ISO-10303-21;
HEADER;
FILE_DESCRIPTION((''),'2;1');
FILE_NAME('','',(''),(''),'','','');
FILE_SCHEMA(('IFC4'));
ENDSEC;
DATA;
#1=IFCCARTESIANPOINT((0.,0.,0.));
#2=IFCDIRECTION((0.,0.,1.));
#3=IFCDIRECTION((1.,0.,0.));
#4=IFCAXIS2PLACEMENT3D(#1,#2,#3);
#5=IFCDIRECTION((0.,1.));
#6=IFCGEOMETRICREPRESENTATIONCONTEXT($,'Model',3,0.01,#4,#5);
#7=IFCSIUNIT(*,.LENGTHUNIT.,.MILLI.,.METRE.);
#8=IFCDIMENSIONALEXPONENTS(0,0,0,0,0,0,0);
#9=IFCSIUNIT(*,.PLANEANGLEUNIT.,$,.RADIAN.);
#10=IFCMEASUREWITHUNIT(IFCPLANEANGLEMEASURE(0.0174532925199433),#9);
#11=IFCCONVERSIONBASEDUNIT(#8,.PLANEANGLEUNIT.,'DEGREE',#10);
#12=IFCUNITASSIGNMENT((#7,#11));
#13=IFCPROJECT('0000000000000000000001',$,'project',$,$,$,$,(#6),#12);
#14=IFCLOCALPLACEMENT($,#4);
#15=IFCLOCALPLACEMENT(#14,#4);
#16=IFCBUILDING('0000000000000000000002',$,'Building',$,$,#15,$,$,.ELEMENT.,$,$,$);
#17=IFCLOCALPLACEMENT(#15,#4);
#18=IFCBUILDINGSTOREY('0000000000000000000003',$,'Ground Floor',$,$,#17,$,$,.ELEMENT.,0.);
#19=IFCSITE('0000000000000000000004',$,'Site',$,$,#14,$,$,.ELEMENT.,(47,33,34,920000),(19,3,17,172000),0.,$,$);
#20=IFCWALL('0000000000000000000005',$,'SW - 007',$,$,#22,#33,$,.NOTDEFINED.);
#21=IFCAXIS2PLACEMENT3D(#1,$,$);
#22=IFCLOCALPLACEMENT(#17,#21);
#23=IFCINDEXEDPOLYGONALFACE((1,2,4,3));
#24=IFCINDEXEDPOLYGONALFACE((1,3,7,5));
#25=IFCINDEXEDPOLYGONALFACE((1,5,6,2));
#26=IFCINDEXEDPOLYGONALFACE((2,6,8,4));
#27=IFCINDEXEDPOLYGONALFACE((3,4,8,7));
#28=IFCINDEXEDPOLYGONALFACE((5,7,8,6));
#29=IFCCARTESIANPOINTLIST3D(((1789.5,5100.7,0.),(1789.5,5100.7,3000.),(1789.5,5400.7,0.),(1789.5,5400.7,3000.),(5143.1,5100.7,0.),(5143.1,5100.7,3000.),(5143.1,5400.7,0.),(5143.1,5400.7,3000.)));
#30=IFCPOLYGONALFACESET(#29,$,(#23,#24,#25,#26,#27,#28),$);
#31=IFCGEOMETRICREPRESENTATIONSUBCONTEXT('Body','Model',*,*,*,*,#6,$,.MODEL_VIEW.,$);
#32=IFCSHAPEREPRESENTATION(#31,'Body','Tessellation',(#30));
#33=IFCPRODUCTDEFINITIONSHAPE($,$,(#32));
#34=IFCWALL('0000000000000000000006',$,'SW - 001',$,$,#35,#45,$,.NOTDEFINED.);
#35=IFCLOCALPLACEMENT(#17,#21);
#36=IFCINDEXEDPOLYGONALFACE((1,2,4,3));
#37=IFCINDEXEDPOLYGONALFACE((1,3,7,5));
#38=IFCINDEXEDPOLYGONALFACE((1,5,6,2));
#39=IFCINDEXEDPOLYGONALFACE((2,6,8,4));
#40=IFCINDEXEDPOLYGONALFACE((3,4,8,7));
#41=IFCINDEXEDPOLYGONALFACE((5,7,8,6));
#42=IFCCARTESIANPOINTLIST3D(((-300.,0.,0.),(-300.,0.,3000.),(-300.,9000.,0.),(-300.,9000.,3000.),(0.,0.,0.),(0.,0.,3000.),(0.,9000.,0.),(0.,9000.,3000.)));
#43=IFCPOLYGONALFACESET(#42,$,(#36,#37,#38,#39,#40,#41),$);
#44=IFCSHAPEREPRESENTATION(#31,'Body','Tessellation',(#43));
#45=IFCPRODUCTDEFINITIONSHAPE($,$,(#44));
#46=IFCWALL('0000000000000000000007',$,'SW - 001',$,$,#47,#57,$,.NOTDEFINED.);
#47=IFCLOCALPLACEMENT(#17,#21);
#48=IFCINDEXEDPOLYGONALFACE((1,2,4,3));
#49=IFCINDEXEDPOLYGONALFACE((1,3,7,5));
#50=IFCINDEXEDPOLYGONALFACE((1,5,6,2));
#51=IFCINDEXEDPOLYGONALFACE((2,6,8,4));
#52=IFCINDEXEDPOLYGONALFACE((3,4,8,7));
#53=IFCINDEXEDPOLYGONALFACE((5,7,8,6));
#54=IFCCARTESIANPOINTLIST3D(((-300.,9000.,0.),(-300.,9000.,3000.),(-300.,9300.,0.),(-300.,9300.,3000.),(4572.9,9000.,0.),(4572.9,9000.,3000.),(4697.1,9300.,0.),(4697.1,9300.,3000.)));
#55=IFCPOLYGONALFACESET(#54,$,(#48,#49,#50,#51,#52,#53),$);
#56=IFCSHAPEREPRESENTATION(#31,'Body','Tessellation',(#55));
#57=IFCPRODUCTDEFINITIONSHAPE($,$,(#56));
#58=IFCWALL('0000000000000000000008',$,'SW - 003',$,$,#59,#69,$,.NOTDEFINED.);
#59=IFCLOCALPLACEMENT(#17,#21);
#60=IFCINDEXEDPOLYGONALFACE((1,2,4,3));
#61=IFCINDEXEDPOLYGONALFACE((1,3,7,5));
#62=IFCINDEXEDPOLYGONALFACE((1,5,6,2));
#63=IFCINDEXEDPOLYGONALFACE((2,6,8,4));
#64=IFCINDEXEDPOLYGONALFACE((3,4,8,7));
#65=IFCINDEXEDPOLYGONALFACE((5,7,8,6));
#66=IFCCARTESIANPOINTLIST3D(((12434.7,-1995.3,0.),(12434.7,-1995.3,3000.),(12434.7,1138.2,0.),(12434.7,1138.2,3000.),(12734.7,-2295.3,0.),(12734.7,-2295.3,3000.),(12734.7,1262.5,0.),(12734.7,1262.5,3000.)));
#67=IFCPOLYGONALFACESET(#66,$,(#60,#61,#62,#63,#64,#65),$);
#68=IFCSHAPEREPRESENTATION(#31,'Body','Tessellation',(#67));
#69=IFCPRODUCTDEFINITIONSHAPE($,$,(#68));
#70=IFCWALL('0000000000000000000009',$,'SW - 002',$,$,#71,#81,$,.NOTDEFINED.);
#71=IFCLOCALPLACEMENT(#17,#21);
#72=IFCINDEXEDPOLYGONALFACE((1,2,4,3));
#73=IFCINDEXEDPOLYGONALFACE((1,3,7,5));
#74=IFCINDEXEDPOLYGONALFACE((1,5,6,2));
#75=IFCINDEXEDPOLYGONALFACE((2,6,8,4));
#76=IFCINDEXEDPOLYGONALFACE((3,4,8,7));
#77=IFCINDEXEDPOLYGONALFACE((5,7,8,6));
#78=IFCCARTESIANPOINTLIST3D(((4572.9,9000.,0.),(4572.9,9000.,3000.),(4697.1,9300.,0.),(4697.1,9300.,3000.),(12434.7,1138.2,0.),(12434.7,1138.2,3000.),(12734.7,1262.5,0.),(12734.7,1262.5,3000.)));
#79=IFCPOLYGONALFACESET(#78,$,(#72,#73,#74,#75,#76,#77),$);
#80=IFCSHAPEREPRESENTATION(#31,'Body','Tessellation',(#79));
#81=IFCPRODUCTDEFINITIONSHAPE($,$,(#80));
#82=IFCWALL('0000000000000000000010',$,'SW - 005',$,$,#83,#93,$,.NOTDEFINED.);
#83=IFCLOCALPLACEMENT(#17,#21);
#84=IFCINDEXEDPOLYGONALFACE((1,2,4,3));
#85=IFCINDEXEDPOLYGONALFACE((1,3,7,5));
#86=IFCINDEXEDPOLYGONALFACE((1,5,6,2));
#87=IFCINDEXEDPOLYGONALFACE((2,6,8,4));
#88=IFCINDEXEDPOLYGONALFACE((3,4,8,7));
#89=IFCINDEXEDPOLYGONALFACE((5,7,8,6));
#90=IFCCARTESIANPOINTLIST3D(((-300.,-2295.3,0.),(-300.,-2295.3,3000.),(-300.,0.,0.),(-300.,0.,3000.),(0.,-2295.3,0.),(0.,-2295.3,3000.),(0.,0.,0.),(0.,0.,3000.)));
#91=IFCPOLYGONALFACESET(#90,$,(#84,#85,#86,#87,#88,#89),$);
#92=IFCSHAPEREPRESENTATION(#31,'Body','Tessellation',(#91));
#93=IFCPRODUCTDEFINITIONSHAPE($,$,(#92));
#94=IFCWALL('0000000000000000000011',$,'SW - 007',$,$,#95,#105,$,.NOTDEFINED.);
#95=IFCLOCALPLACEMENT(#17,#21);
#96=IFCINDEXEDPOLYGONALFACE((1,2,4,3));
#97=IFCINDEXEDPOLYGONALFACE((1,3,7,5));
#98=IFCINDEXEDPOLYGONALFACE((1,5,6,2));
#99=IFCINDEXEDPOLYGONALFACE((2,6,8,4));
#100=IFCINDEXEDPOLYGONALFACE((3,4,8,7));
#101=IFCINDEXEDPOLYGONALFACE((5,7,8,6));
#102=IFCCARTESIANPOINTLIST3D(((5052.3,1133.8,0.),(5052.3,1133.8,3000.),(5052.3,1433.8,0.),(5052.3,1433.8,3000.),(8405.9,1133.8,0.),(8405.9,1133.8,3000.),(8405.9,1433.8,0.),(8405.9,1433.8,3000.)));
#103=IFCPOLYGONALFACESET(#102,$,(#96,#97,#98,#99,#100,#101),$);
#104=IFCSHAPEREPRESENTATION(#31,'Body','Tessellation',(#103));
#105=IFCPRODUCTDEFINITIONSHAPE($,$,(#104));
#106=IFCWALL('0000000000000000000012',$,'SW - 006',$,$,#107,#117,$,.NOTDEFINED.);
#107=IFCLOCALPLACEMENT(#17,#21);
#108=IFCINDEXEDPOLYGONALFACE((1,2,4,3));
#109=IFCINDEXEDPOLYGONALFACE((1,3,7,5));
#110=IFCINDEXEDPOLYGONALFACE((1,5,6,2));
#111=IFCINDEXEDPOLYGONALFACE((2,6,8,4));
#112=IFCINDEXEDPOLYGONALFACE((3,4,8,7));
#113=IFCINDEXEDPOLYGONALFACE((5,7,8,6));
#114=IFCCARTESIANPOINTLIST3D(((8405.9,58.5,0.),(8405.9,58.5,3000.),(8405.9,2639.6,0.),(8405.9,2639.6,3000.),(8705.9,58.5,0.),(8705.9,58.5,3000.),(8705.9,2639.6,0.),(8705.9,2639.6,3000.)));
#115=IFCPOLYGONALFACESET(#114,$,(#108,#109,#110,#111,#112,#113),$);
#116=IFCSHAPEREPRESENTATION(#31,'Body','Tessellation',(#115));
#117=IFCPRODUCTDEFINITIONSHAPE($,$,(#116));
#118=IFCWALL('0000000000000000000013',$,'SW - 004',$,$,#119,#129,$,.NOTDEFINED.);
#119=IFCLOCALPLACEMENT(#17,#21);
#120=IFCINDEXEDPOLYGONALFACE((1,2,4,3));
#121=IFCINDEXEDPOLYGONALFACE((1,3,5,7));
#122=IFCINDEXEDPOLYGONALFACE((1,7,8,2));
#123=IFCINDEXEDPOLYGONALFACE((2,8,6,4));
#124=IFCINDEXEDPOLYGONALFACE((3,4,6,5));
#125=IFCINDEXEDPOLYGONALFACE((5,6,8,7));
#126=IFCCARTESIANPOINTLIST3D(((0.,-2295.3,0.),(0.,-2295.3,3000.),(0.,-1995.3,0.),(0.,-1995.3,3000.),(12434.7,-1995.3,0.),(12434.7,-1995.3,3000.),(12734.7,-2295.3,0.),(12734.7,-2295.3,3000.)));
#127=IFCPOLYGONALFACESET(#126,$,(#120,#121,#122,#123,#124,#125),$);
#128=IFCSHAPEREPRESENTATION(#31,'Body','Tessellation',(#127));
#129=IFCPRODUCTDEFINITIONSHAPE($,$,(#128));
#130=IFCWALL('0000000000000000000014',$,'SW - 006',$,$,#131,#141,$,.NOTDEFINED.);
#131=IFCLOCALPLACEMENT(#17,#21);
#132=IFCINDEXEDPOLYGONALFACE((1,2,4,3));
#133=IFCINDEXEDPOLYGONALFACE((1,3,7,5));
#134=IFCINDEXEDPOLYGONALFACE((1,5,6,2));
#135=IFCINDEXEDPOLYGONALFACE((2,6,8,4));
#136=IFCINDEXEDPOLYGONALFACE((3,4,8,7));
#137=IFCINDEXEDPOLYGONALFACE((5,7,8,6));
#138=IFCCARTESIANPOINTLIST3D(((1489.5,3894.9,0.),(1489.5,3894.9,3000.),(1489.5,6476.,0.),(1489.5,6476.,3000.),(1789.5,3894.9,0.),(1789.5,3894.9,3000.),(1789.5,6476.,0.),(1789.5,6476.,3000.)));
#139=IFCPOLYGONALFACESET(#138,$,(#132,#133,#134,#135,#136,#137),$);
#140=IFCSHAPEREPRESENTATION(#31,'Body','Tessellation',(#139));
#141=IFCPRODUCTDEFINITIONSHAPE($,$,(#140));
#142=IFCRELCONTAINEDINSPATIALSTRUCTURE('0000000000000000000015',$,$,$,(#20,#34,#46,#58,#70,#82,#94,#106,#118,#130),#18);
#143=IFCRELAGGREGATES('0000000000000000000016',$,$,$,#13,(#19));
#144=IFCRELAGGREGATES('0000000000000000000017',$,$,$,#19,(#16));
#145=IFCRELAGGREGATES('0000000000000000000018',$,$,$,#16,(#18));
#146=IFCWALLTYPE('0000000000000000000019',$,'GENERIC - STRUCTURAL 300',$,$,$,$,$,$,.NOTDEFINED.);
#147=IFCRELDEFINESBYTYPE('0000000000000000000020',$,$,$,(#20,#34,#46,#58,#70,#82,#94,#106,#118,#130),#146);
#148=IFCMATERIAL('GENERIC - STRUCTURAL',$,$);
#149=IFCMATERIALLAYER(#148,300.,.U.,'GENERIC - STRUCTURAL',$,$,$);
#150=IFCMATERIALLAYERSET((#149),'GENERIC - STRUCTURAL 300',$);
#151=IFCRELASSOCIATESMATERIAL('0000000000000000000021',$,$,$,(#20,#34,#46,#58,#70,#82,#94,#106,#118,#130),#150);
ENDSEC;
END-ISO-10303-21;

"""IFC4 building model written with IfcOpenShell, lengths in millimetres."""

from ifc_helpers import new_model, entity, si_unit, converted_unit, direction, frame, origin_with_axes, place, context, subcontext, project, spatial, line, indexed_curve, outline, extrude, material, layer, layer_set, layer_usage, type_object, element, save


model = new_model("IFC4")

# Units and contexts
model_context = context("Model", 3, precision=0.01, world=origin_with_axes(), true_north=direction((0.0, 1.0)))
body_context = subcontext(model_context, "Body", "Model", "MODEL_VIEW")
ifc_project = project(units=[si_unit("LENGTHUNIT", "METRE", prefix="MILLI"), converted_unit("PLANEANGLEUNIT", "DEGREE", entity("IfcPlaneAngleMeasure", 0.0174532925199433), si_unit("PLANEANGLEUNIT", "RADIAN"), dimensions=[0, 0, 0, 0, 0, 0, 0])], contexts=[model_context])

# Site, building, storey
site_placement = place(None, origin_with_axes())
site = spatial("IfcSite", under=ifc_project, at=site_placement, Name="Site", CompositionType="ELEMENT", RefLatitude=(47, 33, 34, 920000), RefLongitude=(19, 3, 17, 172000), RefElevation=0.0)
building_placement = place(site_placement, origin_with_axes())
building = spatial("IfcBuilding", under=site, at=building_placement, Name="Building", CompositionType="ELEMENT")
storey_placement = place(building_placement, origin_with_axes())
storey = spatial("IfcBuildingStorey", under=building, at=storey_placement, Name="Ground Floor", CompositionType="ELEMENT", Elevation=0.0)

# Walls
ifc_material = material(Name="GENERIC - STRUCTURAL")
ifc_layer = layer(ifc_material, 300.0, ventilated="UNKNOWN", Name="GENERIC - STRUCTURAL")
ifc_layer_set = layer_set([ifc_layer], Name="GENERIC - STRUCTURAL 300")
ifc_layer_usage_1 = layer_usage(ifc_layer_set, "AXIS2", "POSITIVE", 0.0)
wall_type = type_object("IfcWallType", Name="GENERIC - STRUCTURAL 300", PredefinedType="NOTDEFINED")
wall_1_placement = place(storey_placement, frame((1789.5, 5100.7, 0.0), z_axis=(0.0, 0.0, 1.0), x_axis=(1.0, 0.0, 0.0)))
element("IfcWall", 1, at=wall_1_placement, inside=storey, type_object=wall_type, material=ifc_layer_usage_1, Name="SW - 007", PredefinedType="NOTDEFINED", context=body_context, shape_type="SweptSolid", body=[
    extrude(outline(indexed_curve([(0.0, 0.0), (3353.6, 0.0), (3353.6, 300.0), (0.0, 300.0)], segments=[line(1, 2, 3, 4, 1)])), origin_with_axes(), (0.0, 0.0, 1.0), 3000.0),
])
ifc_layer_usage_2 = layer_usage(ifc_layer_set, "AXIS2", "POSITIVE", 0.0)
wall_2_placement = place(storey_placement, frame((0.0, 0.0, 0.0), z_axis=(0.0, 0.0, 1.0), x_axis=(0.0, 1.0, 0.0)))
element("IfcWall", 2, at=wall_2_placement, inside=storey, type_object=wall_type, material=ifc_layer_usage_2, Name="SW - 001", PredefinedType="NOTDEFINED", context=body_context, shape_type="SweptSolid", body=[
    extrude(outline(indexed_curve([(0.0, 0.0), (9000.0, 0.0), (9000.0, 300.0), (0.0, 300.0)], segments=[line(1, 2, 3, 4, 1)])), origin_with_axes(), (0.0, 0.0, 1.0), 3000.0),
])
ifc_layer_usage_3 = layer_usage(ifc_layer_set, "AXIS2", "POSITIVE", 0.0)
wall_3_placement = place(storey_placement, frame((-300.0, 9000.0, 0.0), z_axis=(0.0, 0.0, 1.0), x_axis=(1.0, 0.0, 0.0)))
element("IfcWall", 3, at=wall_3_placement, inside=storey, type_object=wall_type, material=ifc_layer_usage_3, Name="SW - 001", PredefinedType="NOTDEFINED", context=body_context, shape_type="SweptSolid", body=[
    extrude(outline(indexed_curve([(0.0, 0.0), (4872.9, 0.0), (4997.1, 300.0), (0.0, 300.0)], segments=[line(1, 2, 3, 4, 1)])), origin_with_axes(), (0.0, 0.0, 1.0), 3000.0),
])
ifc_layer_usage_4 = layer_usage(ifc_layer_set, "AXIS2", "POSITIVE", 0.0)
wall_4_placement = place(storey_placement, frame((12434.7, 1138.2, 0.0), z_axis=(0.0, 0.0, 1.0), x_axis=(0.0, -1.0, 0.0)))
element("IfcWall", 4, at=wall_4_placement, inside=storey, type_object=wall_type, material=ifc_layer_usage_4, Name="SW - 003", PredefinedType="NOTDEFINED", context=body_context, shape_type="SweptSolid", body=[
    extrude(outline(indexed_curve([(0.0, 0.0), (3133.5, 0.0), (3433.5, 300.0), (-124.3, 300.0)], segments=[line(1, 2, 3, 4, 1)])), origin_with_axes(), (0.0, 0.0, 1.0), 3000.0),
])
ifc_layer_usage_5 = layer_usage(ifc_layer_set, "AXIS2", "POSITIVE", 0.0)
wall_5_placement = place(storey_placement, frame((4572.9, 9000.0, 0.0), z_axis=(0.0, 0.0, 1.0), x_axis=(0.707107, -0.707107, 0.0)))
element("IfcWall", 5, at=wall_5_placement, inside=storey, type_object=wall_type, material=ifc_layer_usage_5, Name="SW - 002", PredefinedType="NOTDEFINED", context=body_context, shape_type="SweptSolid", body=[
    extrude(outline(indexed_curve([(0.0, 0.0), (11118.3, 0.0), (11242.5, 300.0), (-124.3, 300.0)], segments=[line(1, 2, 3, 4, 1)])), origin_with_axes(), (0.0, 0.0, 1.0), 3000.0),
])
ifc_layer_usage_6 = layer_usage(ifc_layer_set, "AXIS2", "POSITIVE", 0.0)
wall_6_placement = place(storey_placement, frame((0.0, -2295.3, 0.0), z_axis=(0.0, 0.0, 1.0), x_axis=(0.0, 1.0, 0.0)))
element("IfcWall", 6, at=wall_6_placement, inside=storey, type_object=wall_type, material=ifc_layer_usage_6, Name="SW - 005", PredefinedType="NOTDEFINED", context=body_context, shape_type="SweptSolid", body=[
    extrude(outline(indexed_curve([(0.0, 0.0), (2295.3, 0.0), (2295.3, 300.0), (0.0, 300.0)], segments=[line(1, 2, 3, 4, 1)])), origin_with_axes(), (0.0, 0.0, 1.0), 3000.0),
])
ifc_layer_usage_7 = layer_usage(ifc_layer_set, "AXIS2", "POSITIVE", 0.0)
wall_7_placement = place(storey_placement, frame((8405.9, 1433.8, 0.0), z_axis=(0.0, 0.0, 1.0), x_axis=(-1.0, 0.0, 0.0)))
element("IfcWall", 7, at=wall_7_placement, inside=storey, type_object=wall_type, material=ifc_layer_usage_7, Name="SW - 007", PredefinedType="NOTDEFINED", context=body_context, shape_type="SweptSolid", body=[
    extrude(outline(indexed_curve([(0.0, 0.0), (3353.6, 0.0), (3353.6, 300.0), (0.0, 300.0)], segments=[line(1, 2, 3, 4, 1)])), origin_with_axes(), (0.0, 0.0, 1.0), 3000.0),
])
ifc_layer_usage_8 = layer_usage(ifc_layer_set, "AXIS2", "POSITIVE", 0.0)
wall_8_placement = place(storey_placement, frame((8405.9, 2639.6, 0.0), z_axis=(0.0, 0.0, 1.0), x_axis=(0.0, -1.0, 0.0)))
element("IfcWall", 8, at=wall_8_placement, inside=storey, type_object=wall_type, material=ifc_layer_usage_8, Name="SW - 006", PredefinedType="NOTDEFINED", context=body_context, shape_type="SweptSolid", body=[
    extrude(outline(indexed_curve([(0.0, 0.0), (2581.1, 0.0), (2581.1, 300.0), (0.0, 300.0)], segments=[line(1, 2, 3, 4, 1)])), origin_with_axes(), (0.0, 0.0, 1.0), 3000.0),
])
ifc_layer_usage_9 = layer_usage(ifc_layer_set, "AXIS2", "POSITIVE", 0.0)
wall_9_placement = place(storey_placement, frame((12434.7, -1995.3, 0.0), z_axis=(0.0, 0.0, 1.0), x_axis=(-1.0, 0.0, 0.0)))
element("IfcWall", 9, at=wall_9_placement, inside=storey, type_object=wall_type, material=ifc_layer_usage_9, Name="SW - 004", PredefinedType="NOTDEFINED", context=body_context, shape_type="SweptSolid", body=[
    extrude(outline(indexed_curve([(0.0, 0.0), (12434.7, 0.0), (12434.7, 300.0), (-300.0, 300.0)], segments=[line(1, 2, 3, 4, 1)])), origin_with_axes(), (0.0, 0.0, 1.0), 3000.0),
])
ifc_layer_usage_10 = layer_usage(ifc_layer_set, "AXIS2", "POSITIVE", 0.0)
wall_10_placement = place(storey_placement, frame((1789.5, 3894.9, 0.0), z_axis=(0.0, 0.0, 1.0), x_axis=(0.0, 1.0, 0.0)))
element("IfcWall", 10, at=wall_10_placement, inside=storey, type_object=wall_type, material=ifc_layer_usage_10, Name="SW - 006", PredefinedType="NOTDEFINED", context=body_context, shape_type="SweptSolid", body=[
    extrude(outline(indexed_curve([(0.0, 0.0), (2581.1, 0.0), (2581.1, 300.0), (0.0, 300.0)], segments=[line(1, 2, 3, 4, 1)])), origin_with_axes(), (0.0, 0.0, 1.0), 3000.0),
])

save(model, "model.ifc")
